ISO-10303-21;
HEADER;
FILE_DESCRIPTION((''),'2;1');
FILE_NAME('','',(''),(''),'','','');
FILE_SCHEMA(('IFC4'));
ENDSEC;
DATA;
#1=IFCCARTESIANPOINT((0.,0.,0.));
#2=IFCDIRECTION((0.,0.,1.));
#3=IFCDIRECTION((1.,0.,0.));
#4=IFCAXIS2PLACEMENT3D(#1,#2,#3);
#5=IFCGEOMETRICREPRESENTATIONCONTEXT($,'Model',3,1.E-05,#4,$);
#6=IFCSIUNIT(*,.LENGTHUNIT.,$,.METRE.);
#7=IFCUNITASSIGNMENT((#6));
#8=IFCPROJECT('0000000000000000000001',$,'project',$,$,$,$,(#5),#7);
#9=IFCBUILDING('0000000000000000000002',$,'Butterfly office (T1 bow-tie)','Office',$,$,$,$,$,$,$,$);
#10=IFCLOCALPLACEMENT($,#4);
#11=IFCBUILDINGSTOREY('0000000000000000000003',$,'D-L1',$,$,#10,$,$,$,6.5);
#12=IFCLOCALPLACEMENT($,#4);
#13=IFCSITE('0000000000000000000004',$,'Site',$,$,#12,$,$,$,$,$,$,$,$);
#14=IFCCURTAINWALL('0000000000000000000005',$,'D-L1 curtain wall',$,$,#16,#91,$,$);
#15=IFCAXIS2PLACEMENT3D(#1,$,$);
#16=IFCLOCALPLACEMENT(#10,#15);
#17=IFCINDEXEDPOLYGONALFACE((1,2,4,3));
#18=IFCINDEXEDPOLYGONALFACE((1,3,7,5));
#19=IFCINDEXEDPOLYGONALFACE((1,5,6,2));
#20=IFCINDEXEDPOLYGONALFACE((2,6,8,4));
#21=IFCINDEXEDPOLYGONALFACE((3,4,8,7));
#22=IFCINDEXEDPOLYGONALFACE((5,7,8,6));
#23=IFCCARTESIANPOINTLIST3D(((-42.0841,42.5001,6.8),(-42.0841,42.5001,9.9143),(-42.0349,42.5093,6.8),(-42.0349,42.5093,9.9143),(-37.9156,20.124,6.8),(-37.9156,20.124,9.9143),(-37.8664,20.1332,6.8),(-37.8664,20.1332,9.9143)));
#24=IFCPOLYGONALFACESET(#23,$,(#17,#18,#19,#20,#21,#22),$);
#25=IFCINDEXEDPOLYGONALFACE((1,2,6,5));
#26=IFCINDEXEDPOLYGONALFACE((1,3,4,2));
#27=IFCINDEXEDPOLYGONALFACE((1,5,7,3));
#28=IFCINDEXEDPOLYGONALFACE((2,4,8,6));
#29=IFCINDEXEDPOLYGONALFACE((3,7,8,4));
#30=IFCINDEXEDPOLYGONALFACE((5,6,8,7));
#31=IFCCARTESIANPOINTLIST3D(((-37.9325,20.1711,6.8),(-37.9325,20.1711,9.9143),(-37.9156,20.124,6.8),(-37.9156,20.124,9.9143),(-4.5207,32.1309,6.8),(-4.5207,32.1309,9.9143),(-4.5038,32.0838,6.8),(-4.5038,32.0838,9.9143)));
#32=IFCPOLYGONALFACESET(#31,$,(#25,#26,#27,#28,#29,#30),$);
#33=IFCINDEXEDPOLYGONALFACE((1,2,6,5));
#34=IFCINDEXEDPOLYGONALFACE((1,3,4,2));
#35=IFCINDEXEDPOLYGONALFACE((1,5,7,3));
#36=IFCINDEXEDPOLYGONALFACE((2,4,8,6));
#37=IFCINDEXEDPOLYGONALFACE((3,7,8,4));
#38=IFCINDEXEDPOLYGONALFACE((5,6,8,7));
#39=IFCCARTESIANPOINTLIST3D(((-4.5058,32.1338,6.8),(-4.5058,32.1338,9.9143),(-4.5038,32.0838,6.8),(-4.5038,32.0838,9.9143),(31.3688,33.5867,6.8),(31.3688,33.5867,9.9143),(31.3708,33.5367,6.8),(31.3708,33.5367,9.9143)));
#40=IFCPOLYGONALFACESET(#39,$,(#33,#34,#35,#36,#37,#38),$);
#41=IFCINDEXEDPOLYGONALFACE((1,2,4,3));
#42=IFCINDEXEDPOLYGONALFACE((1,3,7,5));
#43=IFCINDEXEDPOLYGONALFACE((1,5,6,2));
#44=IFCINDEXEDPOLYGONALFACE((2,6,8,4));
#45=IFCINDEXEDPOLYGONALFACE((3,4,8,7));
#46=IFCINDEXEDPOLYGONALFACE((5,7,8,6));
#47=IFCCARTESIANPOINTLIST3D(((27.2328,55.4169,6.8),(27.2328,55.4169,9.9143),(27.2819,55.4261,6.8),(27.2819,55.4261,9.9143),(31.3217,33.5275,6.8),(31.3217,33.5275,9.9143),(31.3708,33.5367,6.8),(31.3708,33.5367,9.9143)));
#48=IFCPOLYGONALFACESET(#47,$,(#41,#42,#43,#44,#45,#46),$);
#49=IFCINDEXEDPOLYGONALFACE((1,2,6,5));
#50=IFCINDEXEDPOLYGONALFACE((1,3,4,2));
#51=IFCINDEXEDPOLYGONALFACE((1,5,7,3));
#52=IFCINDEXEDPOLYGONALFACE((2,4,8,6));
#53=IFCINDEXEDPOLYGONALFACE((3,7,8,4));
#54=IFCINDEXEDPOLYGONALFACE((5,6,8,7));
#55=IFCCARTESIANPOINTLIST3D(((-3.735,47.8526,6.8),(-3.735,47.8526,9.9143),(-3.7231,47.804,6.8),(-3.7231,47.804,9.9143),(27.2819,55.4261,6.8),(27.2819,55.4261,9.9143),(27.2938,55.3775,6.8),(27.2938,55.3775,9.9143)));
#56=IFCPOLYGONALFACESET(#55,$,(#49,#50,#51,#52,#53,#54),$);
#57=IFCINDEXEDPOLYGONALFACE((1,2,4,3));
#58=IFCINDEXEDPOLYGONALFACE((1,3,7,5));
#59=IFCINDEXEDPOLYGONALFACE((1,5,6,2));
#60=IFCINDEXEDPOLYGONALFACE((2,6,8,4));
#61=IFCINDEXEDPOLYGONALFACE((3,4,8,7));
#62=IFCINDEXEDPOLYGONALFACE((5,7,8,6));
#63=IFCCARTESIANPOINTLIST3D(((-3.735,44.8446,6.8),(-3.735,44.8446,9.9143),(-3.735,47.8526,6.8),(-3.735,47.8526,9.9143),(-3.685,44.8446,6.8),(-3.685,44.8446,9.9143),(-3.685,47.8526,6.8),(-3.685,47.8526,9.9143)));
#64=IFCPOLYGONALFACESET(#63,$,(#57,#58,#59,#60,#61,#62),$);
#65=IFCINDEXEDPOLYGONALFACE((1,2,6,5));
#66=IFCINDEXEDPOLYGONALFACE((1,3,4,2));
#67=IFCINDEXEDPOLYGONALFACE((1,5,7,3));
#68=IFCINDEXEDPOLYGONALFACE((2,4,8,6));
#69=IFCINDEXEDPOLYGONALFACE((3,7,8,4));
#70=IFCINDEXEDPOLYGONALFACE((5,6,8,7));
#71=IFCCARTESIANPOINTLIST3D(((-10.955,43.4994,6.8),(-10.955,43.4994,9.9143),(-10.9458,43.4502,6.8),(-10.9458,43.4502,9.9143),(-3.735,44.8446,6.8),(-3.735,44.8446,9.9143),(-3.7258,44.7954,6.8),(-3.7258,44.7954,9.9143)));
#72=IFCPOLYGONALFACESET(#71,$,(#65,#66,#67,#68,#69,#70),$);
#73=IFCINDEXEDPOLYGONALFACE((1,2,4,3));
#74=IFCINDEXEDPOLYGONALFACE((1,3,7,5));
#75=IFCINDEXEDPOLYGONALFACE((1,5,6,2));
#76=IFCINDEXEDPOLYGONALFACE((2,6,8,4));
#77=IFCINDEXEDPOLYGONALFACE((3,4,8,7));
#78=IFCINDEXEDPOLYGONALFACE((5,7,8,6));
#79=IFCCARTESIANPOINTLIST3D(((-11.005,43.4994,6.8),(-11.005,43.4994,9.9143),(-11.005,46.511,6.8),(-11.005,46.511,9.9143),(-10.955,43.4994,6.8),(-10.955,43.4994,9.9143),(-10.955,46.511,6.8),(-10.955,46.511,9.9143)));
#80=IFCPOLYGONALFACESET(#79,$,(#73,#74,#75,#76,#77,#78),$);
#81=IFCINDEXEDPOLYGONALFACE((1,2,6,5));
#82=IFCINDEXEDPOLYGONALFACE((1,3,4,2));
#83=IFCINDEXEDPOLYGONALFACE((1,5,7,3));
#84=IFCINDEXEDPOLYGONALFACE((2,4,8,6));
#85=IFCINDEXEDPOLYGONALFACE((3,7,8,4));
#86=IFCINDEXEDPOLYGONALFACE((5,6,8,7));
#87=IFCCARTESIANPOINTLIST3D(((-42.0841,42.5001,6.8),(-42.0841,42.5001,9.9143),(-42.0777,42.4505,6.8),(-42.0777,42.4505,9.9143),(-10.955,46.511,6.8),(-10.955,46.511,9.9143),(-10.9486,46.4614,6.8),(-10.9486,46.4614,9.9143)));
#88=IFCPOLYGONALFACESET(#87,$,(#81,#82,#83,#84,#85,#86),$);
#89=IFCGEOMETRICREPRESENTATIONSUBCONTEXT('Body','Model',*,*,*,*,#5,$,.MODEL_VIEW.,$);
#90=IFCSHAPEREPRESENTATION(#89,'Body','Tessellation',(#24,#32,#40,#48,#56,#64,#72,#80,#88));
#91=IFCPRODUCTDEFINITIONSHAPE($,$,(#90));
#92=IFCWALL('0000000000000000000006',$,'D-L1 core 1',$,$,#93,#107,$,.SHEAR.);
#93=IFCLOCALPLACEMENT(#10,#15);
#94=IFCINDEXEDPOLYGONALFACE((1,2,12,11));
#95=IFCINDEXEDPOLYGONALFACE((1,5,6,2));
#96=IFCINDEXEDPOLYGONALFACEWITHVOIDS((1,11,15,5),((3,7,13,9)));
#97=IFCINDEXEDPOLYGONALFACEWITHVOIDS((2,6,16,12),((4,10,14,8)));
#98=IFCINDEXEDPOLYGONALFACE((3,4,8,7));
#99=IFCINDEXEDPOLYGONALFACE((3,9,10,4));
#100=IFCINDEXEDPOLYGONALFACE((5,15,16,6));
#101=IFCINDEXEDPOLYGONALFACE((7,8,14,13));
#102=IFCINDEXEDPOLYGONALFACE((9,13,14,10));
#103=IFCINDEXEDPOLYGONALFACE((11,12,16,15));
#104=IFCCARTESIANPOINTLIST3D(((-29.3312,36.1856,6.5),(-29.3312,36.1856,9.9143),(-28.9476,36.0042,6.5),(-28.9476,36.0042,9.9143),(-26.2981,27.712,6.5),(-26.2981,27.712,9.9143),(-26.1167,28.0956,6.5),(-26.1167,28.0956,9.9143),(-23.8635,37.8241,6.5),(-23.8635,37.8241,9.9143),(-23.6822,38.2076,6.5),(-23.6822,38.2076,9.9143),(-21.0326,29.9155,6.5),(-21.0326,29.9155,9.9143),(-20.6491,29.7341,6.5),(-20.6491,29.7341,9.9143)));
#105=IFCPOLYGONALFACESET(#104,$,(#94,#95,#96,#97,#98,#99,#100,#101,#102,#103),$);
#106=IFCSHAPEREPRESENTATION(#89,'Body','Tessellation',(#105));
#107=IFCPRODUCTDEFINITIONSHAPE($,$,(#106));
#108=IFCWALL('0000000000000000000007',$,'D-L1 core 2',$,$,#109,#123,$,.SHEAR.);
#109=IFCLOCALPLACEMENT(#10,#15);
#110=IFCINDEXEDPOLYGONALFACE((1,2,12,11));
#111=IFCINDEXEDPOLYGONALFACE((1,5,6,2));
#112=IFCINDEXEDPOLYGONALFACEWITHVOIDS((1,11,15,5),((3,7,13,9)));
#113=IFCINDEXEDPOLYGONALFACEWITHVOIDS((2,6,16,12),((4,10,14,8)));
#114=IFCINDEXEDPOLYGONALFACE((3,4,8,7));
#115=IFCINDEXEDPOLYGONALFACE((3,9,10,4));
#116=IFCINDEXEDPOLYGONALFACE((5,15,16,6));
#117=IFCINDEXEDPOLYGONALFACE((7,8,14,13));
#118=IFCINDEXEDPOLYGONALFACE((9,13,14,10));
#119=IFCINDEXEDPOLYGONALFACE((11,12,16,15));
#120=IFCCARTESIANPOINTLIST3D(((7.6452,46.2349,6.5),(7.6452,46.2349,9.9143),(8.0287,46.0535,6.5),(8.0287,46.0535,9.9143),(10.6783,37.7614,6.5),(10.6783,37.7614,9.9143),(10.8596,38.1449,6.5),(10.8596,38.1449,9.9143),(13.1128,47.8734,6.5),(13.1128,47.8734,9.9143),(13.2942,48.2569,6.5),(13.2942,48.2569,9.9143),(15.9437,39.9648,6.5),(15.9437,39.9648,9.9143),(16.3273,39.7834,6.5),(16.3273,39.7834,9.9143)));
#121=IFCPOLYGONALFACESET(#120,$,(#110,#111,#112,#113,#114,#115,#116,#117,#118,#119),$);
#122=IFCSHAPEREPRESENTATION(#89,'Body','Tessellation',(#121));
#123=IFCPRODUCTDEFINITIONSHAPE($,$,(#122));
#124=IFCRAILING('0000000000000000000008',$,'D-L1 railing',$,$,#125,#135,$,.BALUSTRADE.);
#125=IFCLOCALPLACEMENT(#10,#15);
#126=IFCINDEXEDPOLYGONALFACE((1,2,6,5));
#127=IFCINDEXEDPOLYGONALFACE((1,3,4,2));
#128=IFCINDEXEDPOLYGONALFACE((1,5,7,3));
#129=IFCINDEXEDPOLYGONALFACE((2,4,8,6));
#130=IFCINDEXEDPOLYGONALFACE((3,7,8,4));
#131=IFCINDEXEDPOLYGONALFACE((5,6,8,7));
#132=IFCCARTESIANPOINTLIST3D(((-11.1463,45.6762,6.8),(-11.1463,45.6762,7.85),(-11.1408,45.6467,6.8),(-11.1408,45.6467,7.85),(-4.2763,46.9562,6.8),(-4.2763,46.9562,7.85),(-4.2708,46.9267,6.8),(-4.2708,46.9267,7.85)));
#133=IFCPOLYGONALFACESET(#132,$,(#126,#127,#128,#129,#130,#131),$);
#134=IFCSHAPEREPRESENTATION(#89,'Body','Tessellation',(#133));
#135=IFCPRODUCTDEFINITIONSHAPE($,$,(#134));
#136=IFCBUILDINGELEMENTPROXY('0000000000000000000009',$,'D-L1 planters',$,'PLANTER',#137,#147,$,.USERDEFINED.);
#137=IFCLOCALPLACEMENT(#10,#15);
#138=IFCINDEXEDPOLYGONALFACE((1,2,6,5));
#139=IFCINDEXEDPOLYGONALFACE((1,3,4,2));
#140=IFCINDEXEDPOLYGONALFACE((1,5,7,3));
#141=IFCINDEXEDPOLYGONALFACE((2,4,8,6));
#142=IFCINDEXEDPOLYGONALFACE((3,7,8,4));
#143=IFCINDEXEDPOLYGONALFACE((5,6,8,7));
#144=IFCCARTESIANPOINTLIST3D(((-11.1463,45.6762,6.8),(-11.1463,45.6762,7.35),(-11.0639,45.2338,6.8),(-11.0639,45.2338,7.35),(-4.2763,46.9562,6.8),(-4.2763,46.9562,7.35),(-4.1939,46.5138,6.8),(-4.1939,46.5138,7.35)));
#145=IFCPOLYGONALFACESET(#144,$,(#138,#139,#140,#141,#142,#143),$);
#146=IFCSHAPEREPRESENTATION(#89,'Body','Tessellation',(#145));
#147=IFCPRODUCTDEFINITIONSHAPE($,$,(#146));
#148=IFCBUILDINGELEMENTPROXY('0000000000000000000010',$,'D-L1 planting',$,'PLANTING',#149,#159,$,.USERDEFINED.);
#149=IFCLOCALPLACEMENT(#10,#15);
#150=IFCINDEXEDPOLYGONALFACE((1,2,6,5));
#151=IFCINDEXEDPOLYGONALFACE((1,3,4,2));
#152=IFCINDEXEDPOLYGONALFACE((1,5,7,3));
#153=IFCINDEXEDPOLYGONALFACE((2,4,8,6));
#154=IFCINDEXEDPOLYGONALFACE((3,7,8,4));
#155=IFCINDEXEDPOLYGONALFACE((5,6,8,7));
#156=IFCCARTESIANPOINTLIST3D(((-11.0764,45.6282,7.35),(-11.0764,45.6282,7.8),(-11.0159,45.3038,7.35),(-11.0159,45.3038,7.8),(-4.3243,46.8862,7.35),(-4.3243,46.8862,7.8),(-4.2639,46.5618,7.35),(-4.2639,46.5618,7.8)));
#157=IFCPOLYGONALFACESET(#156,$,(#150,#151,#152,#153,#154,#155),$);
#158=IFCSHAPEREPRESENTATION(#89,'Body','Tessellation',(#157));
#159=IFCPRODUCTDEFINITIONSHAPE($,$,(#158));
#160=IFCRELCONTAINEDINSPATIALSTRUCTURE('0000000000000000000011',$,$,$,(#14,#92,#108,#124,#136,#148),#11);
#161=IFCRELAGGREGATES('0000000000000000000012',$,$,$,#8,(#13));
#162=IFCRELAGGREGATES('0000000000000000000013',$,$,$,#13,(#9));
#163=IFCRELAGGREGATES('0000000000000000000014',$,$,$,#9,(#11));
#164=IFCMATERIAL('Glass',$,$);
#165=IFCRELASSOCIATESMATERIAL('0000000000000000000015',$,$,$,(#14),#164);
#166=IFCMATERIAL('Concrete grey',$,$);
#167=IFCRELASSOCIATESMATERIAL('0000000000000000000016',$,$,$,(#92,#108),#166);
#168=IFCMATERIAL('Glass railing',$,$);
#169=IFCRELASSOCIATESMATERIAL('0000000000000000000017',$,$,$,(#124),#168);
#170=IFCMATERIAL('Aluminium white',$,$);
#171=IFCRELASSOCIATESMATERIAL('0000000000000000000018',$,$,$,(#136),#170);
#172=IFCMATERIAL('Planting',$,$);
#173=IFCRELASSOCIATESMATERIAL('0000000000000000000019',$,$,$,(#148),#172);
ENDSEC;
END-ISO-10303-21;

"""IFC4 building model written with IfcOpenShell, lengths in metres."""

from ifc_helpers import new_model, si_unit, frame, origin_with_axes, place, context, subcontext, project, spatial, polyline, outline, extrude, material, element, save


model = new_model("IFC4")

# Units and contexts
model_context = context("Model", 3, precision=1e-05, world=origin_with_axes())
body_context = subcontext(model_context, "Body", "Model", "MODEL_VIEW")
ifc_project = project(units=[si_unit("LENGTHUNIT", "METRE")], contexts=[model_context])

# Site, building, storey
site_placement = place(None, origin_with_axes())
site = spatial("IfcSite", under=ifc_project, at=site_placement, Name="Site")
building = spatial("IfcBuilding", under=site, Name="Butterfly office (T1 bow-tie)", Description="Office")
storey_placement = place(None, origin_with_axes())
storey = spatial("IfcBuildingStorey", under=building, at=storey_placement, Name="D-L1", Elevation=6.5)

# Shared definitions
ifc_material_1 = material(Name="Concrete grey")

# Shared definitions
ifc_material_2 = material(Name="Aluminium white")

# Curtain wall
ifc_material_3 = material(Name="Glass")
curtain_wall_placement = place(storey_placement, origin_with_axes())
element("IfcCurtainWall", 1, at=curtain_wall_placement, inside=storey, material=ifc_material_3, Name="D-L1 curtain wall", context=body_context, shape_type="SweptSolid", body=[
    extrude(outline(polyline([(-42.0841, 42.5001), (-37.9156, 20.124), (-37.8664, 20.1332), (-42.0349, 42.5093), (-42.0841, 42.5001)])), frame((0.0, 0.0, 6.8), z_axis=(0.0, 0.0, 1.0), x_axis=(1.0, 0.0, 0.0)), (0.0, 0.0, 1.0), 3.1143),
    extrude(outline(polyline([(-37.9156, 20.124), (-4.5038, 32.0838), (-4.5207, 32.1309), (-37.9325, 20.1711), (-37.9156, 20.124)])), frame((0.0, 0.0, 6.8), z_axis=(0.0, 0.0, 1.0), x_axis=(1.0, 0.0, 0.0)), (0.0, 0.0, 1.0), 3.1143),
    extrude(outline(polyline([(-4.5038, 32.0838), (31.3708, 33.5367), (31.3688, 33.5867), (-4.5058, 32.1338), (-4.5038, 32.0838)])), frame((0.0, 0.0, 6.8), z_axis=(0.0, 0.0, 1.0), x_axis=(1.0, 0.0, 0.0)), (0.0, 0.0, 1.0), 3.1143),
    extrude(outline(polyline([(31.3708, 33.5367), (27.2819, 55.4261), (27.2328, 55.4169), (31.3217, 33.5275), (31.3708, 33.5367)])), frame((0.0, 0.0, 6.8), z_axis=(0.0, 0.0, 1.0), x_axis=(1.0, 0.0, 0.0)), (0.0, 0.0, 1.0), 3.1143),
    extrude(outline(polyline([(27.2819, 55.4261), (-3.735, 47.8526), (-3.7231, 47.804), (27.2938, 55.3775), (27.2819, 55.4261)])), frame((0.0, 0.0, 6.8), z_axis=(0.0, 0.0, 1.0), x_axis=(1.0, 0.0, 0.0)), (0.0, 0.0, 1.0), 3.1143),
    extrude(outline(polyline([(-3.735, 47.8526), (-3.735, 44.8446), (-3.685, 44.8446), (-3.685, 47.8526), (-3.735, 47.8526)])), frame((0.0, 0.0, 6.8), z_axis=(0.0, 0.0, 1.0), x_axis=(1.0, 0.0, 0.0)), (0.0, 0.0, 1.0), 3.1143),
    extrude(outline(polyline([(-3.735, 44.8446), (-10.955, 43.4994), (-10.9458, 43.4502), (-3.7258, 44.7954), (-3.735, 44.8446)])), frame((0.0, 0.0, 6.8), z_axis=(0.0, 0.0, 1.0), x_axis=(1.0, 0.0, 0.0)), (0.0, 0.0, 1.0), 3.1143),
    extrude(outline(polyline([(-10.955, 43.4994), (-10.955, 46.511), (-11.005, 46.511), (-11.005, 43.4994), (-10.955, 43.4994)])), frame((0.0, 0.0, 6.8), z_axis=(0.0, 0.0, 1.0), x_axis=(1.0, 0.0, 0.0)), (0.0, 0.0, 1.0), 3.1143),
    extrude(outline(polyline([(-10.955, 46.511), (-42.0841, 42.5001), (-42.0777, 42.4505), (-10.9486, 46.4614), (-10.955, 46.511)])), frame((0.0, 0.0, 6.8), z_axis=(0.0, 0.0, 1.0), x_axis=(1.0, 0.0, 0.0)), (0.0, 0.0, 1.0), 3.1143),
])

# Walls
wall_1_placement = place(storey_placement, origin_with_axes())
element("IfcWall", 2, at=wall_1_placement, inside=storey, material=ifc_material_1, Name="D-L1 core 1", PredefinedType="SHEAR", context=body_context, shape_type="SweptSolid", body=[
    extrude(outline(polyline([(-26.2981, 27.712), (-20.6491, 29.7341), (-23.6822, 38.2076), (-29.3312, 36.1856), (-26.2981, 27.712)]), holes=[polyline([(-26.1167, 28.0956), (-21.0326, 29.9155), (-23.8635, 37.8241), (-28.9476, 36.0042), (-26.1167, 28.0956)])]), frame((0.0, 0.0, 6.5), z_axis=(0.0, 0.0, 1.0), x_axis=(1.0, 0.0, 0.0)), (0.0, 0.0, 1.0), 3.4143),
])
wall_2_placement = place(storey_placement, origin_with_axes())
element("IfcWall", 3, at=wall_2_placement, inside=storey, material=ifc_material_1, Name="D-L1 core 2", PredefinedType="SHEAR", context=body_context, shape_type="SweptSolid", body=[
    extrude(outline(polyline([(10.6783, 37.7614), (16.3273, 39.7834), (13.2942, 48.2569), (7.6452, 46.2349), (10.6783, 37.7614)]), holes=[polyline([(10.8596, 38.1449), (15.9437, 39.9648), (13.1128, 47.8734), (8.0287, 46.0535), (10.8596, 38.1449)])]), frame((0.0, 0.0, 6.5), z_axis=(0.0, 0.0, 1.0), x_axis=(1.0, 0.0, 0.0)), (0.0, 0.0, 1.0), 3.4143),
])

# Railing
ifc_material_4 = material(Name="Glass railing")
railing_placement = place(storey_placement, origin_with_axes())
element("IfcRailing", 4, at=railing_placement, inside=storey, material=ifc_material_4, Name="D-L1 railing", PredefinedType="BALUSTRADE", context=body_context, shape_type="SweptSolid", body=[
    extrude(outline(polyline([(-4.2763, 46.9562), (-11.1463, 45.6762), (-11.1408, 45.6467), (-4.2708, 46.9267), (-4.2763, 46.9562)])), frame((0.0, 0.0, 6.8), z_axis=(0.0, 0.0, 1.0), x_axis=(1.0, 0.0, 0.0)), (0.0, 0.0, 1.0), 1.05),
])

# Building element proxies
proxy_1_placement = place(storey_placement, origin_with_axes())
element("IfcBuildingElementProxy", 5, at=proxy_1_placement, inside=storey, material=ifc_material_2, Name="D-L1 planters", ObjectType="PLANTER", PredefinedType="USERDEFINED", context=body_context, shape_type="SweptSolid", body=[
    extrude(outline(polyline([(-4.2763, 46.9562), (-11.1463, 45.6762), (-11.0639, 45.2338), (-4.1939, 46.5138), (-4.2763, 46.9562)])), frame((0.0, 0.0, 6.8), z_axis=(0.0, 0.0, 1.0), x_axis=(1.0, 0.0, 0.0)), (0.0, 0.0, 1.0), 0.55),
])
ifc_material_5 = material(Name="Planting")
proxy_2_placement = place(storey_placement, origin_with_axes())
element("IfcBuildingElementProxy", 6, at=proxy_2_placement, inside=storey, material=ifc_material_5, Name="D-L1 planting", ObjectType="PLANTING", PredefinedType="USERDEFINED", context=body_context, shape_type="SweptSolid", body=[
    extrude(outline(polyline([(-4.3243, 46.8862), (-11.0764, 45.6282), (-11.0159, 45.3038), (-4.2639, 46.5618), (-4.3243, 46.8862)])), frame((0.0, 0.0, 7.35), z_axis=(0.0, 0.0, 1.0), x_axis=(1.0, 0.0, 0.0)), (0.0, 0.0, 1.0), 0.45),
])

save(model, "model.ifc")
